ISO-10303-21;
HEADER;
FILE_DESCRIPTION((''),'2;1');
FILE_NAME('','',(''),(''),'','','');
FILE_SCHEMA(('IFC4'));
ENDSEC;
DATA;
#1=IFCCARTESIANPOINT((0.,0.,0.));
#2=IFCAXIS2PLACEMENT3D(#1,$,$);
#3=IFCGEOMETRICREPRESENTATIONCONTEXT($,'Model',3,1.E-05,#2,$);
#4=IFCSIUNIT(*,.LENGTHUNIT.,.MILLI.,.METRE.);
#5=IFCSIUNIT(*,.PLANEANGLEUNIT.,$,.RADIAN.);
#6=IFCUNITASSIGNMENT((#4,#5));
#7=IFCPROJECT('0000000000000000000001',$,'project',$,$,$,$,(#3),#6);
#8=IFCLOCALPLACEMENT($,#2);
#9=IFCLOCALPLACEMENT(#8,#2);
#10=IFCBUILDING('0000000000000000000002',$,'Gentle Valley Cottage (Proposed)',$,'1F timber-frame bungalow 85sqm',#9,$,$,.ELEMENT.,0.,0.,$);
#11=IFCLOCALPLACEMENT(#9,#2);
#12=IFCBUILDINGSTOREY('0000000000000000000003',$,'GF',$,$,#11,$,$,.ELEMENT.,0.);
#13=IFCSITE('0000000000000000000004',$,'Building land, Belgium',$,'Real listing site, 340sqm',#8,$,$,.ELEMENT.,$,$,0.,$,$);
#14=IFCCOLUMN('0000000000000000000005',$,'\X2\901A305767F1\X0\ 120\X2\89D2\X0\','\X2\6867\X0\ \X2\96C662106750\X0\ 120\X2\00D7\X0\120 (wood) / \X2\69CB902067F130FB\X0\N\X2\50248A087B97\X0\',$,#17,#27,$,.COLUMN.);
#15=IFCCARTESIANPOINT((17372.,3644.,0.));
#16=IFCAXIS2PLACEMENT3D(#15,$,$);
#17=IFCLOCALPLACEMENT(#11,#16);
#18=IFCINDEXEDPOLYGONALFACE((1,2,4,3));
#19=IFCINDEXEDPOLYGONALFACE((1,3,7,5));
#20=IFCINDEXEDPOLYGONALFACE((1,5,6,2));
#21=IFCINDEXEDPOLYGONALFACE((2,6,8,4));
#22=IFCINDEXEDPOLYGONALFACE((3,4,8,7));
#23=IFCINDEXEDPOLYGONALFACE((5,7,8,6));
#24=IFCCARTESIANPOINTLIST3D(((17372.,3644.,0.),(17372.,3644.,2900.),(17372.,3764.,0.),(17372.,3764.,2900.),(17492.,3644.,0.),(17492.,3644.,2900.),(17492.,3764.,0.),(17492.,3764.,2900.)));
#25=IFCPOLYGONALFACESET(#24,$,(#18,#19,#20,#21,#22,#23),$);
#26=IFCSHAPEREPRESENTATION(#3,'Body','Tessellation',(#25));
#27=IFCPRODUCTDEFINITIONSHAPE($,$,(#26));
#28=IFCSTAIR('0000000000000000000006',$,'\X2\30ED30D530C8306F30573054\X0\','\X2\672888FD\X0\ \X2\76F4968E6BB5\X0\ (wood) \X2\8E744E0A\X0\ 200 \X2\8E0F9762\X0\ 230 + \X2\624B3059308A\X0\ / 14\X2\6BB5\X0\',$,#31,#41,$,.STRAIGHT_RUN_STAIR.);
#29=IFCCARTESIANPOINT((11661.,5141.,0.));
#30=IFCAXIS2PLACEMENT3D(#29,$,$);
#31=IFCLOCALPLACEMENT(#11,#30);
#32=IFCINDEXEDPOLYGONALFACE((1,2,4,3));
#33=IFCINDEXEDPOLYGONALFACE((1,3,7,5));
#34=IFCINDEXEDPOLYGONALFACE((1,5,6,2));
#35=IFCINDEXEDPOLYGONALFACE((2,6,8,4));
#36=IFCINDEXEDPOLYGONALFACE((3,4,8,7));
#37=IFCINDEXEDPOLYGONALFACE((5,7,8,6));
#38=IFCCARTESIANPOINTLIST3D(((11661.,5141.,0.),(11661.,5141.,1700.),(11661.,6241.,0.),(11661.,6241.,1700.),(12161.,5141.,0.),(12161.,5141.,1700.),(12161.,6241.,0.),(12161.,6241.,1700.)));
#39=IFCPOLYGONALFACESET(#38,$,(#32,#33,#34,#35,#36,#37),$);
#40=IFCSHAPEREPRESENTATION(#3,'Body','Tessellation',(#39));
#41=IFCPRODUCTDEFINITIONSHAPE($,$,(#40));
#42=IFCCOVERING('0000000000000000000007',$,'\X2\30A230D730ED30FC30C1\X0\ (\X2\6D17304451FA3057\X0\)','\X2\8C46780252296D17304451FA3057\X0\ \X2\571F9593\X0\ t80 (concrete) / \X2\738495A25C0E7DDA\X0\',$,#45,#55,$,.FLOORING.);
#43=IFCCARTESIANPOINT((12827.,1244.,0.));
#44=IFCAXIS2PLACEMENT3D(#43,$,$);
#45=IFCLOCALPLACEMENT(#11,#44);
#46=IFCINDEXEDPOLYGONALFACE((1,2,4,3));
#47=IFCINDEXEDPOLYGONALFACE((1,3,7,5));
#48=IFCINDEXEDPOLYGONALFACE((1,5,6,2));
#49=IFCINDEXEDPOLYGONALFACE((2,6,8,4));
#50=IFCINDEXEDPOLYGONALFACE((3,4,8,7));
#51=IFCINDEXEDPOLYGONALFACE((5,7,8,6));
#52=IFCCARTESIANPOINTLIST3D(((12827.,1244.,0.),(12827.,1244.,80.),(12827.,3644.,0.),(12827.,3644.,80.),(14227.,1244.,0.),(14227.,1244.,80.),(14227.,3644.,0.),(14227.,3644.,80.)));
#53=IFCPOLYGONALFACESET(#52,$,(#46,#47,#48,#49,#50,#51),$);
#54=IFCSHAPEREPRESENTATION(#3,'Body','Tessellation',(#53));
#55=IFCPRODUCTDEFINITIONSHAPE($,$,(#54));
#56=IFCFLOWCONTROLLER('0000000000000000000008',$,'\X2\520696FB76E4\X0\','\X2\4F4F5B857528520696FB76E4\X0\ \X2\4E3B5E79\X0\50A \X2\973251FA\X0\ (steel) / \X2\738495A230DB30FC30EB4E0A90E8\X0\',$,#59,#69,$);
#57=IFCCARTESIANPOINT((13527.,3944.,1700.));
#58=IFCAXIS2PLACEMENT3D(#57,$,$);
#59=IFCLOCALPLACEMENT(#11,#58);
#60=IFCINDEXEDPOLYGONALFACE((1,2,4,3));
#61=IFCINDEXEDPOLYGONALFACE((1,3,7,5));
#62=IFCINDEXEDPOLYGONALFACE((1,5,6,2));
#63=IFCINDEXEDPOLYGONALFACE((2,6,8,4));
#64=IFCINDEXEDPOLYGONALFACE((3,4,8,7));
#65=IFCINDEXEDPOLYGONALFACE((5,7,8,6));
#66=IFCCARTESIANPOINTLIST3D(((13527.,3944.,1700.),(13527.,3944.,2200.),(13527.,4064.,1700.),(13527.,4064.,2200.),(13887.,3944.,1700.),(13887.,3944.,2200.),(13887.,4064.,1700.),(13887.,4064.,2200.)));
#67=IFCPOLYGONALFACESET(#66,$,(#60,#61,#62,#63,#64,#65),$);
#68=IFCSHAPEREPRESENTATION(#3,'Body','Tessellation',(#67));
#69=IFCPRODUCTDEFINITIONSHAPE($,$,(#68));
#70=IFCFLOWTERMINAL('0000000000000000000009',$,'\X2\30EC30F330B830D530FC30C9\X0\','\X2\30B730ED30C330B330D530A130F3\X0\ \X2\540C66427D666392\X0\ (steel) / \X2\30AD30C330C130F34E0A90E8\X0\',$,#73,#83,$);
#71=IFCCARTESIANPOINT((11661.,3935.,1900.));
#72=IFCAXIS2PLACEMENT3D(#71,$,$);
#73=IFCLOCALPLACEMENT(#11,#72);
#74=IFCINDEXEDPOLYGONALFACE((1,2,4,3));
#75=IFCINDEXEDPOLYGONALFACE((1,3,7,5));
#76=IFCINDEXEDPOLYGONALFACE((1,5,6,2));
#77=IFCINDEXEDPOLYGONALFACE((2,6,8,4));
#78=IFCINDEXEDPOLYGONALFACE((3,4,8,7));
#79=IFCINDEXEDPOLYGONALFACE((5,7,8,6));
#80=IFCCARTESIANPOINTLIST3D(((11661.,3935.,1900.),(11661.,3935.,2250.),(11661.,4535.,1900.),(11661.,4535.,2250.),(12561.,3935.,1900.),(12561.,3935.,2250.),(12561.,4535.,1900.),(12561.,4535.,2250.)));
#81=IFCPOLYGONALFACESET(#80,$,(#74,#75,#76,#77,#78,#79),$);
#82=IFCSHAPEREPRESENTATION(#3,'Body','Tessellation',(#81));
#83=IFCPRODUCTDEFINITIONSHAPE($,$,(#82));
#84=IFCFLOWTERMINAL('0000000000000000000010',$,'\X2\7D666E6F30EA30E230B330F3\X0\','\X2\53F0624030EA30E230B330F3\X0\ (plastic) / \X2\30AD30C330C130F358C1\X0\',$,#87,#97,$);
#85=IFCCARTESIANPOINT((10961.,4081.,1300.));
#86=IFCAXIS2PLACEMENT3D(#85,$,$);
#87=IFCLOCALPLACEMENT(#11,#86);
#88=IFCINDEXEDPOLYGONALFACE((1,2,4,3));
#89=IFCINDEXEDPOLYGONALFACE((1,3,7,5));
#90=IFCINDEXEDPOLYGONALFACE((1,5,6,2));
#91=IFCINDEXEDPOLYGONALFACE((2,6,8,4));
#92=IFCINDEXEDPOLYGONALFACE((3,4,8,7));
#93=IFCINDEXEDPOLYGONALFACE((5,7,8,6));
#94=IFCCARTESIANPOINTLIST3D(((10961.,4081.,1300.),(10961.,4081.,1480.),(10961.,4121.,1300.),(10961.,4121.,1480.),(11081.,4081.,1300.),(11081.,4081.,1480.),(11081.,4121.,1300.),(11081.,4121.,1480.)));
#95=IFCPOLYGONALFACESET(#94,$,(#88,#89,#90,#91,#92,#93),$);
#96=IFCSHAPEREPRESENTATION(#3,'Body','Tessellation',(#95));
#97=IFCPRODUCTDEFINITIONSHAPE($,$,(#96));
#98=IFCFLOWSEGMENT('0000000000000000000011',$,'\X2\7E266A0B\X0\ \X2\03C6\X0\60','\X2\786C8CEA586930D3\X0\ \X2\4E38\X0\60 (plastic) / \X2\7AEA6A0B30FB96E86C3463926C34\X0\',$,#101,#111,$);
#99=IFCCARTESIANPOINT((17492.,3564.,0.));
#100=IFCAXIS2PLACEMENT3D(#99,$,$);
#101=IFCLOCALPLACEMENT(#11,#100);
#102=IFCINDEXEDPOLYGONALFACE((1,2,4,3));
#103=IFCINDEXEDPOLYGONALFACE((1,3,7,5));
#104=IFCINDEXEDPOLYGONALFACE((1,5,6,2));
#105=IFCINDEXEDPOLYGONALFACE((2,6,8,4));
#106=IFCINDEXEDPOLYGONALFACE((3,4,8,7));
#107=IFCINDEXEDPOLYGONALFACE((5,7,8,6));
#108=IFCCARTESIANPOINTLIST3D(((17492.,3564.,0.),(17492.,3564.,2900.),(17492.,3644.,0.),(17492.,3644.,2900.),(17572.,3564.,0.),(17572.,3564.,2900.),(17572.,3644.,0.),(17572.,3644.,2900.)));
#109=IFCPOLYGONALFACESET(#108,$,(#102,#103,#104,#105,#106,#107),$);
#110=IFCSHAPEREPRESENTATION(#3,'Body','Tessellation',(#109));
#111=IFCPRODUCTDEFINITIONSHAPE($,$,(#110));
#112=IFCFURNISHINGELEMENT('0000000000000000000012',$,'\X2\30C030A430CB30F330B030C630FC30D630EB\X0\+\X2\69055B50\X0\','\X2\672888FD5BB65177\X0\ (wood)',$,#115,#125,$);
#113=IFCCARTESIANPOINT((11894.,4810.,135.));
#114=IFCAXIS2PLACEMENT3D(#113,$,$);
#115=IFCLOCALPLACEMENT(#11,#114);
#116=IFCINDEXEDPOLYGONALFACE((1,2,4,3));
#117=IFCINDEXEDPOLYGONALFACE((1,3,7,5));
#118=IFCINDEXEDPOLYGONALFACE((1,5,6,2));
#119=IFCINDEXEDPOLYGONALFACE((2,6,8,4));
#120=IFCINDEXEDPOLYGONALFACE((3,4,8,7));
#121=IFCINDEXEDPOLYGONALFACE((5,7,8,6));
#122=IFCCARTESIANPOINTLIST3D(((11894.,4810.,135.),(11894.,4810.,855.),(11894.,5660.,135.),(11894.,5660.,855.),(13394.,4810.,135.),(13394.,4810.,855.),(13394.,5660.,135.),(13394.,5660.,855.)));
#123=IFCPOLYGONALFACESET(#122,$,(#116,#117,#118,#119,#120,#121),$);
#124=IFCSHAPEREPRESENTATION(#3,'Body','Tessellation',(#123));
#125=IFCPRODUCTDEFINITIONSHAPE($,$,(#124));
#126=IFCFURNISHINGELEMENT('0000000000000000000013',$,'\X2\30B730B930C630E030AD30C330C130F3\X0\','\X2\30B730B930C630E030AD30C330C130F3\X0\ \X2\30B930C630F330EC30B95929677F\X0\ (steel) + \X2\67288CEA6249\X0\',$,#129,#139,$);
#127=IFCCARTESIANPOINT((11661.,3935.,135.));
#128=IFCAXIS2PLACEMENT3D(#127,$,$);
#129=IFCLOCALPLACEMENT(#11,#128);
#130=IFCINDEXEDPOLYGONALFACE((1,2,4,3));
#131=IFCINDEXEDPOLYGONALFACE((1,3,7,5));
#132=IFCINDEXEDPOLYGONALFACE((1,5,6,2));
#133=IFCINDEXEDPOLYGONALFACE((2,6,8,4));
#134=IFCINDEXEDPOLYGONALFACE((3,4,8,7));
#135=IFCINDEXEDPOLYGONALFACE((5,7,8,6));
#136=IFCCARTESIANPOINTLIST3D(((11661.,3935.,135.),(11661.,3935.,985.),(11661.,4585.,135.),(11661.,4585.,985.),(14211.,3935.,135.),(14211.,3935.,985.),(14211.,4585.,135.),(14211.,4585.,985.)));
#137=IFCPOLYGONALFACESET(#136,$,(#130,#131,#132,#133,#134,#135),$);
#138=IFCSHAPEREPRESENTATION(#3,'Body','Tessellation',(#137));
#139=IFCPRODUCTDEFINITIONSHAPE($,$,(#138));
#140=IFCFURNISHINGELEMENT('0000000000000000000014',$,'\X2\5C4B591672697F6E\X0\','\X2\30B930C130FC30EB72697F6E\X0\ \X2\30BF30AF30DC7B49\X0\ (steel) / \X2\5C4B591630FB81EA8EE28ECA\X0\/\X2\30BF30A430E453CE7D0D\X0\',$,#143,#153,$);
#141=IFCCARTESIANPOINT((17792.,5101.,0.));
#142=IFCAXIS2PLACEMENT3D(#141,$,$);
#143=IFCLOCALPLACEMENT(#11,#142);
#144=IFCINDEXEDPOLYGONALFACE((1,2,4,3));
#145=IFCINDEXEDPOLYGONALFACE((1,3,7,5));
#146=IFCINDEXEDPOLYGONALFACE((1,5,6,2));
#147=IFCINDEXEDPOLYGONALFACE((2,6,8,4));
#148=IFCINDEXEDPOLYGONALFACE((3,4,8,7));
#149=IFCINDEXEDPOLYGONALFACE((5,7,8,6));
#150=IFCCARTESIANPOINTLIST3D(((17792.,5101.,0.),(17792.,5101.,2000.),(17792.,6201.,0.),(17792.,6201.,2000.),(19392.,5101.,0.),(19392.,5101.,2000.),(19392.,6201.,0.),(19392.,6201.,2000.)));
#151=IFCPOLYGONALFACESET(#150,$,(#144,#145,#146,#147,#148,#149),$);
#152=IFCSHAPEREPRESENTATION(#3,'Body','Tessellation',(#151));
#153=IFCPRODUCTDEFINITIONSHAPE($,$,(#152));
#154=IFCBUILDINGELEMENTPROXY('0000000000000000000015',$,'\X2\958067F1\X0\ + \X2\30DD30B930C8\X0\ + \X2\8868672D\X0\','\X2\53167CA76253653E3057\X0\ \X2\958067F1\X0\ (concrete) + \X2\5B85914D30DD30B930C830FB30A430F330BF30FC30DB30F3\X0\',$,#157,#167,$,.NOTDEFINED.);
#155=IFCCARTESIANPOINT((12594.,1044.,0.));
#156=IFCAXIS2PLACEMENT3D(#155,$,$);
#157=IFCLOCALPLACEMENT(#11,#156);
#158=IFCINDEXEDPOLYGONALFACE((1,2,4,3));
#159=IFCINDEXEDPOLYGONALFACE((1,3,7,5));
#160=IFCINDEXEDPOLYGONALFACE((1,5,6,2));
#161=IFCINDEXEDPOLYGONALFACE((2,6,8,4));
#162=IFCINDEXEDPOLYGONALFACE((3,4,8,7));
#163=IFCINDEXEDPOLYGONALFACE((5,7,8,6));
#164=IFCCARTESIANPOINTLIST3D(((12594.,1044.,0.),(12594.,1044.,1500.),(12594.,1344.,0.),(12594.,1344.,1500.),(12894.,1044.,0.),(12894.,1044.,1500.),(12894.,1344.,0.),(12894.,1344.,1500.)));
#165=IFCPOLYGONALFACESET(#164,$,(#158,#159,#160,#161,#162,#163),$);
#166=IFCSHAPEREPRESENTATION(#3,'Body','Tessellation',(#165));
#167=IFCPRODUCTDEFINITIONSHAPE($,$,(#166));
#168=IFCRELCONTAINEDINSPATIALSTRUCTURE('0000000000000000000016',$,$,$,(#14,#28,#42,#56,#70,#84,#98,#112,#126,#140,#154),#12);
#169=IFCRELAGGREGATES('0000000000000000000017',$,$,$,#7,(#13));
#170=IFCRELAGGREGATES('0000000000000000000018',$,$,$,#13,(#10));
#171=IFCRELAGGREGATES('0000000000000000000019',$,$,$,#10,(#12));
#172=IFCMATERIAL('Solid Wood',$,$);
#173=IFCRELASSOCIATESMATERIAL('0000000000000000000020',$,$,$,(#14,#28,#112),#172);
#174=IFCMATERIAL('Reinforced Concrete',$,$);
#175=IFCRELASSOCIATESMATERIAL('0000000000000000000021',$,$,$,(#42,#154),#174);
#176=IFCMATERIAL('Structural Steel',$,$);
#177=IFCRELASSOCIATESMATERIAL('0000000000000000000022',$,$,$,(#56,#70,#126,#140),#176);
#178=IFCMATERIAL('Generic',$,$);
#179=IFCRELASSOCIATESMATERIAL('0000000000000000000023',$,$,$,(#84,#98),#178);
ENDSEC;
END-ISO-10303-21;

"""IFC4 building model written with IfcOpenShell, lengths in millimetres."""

from ifc_helpers import new_model, si_unit, frame, frame_2d, origin, place, context, project, spatial, rectangle, extrude, material, element, save


model = new_model("IFC4")

# Units and contexts
model_context = context("Model", 3, precision=1e-05, world=origin())
ifc_project = project(units=[si_unit("LENGTHUNIT", "METRE", prefix="MILLI"), si_unit("PLANEANGLEUNIT", "RADIAN")], contexts=[model_context])

# Site, building, storey
site_placement = place(None, origin())
site = spatial("IfcSite", under=ifc_project, at=site_placement, Name="Building land, Belgium", ObjectType="Real listing site, 340sqm", CompositionType="ELEMENT", RefElevation=0.0)
building_placement = place(site_placement, origin())
building = spatial("IfcBuilding", under=site, at=building_placement, Name="Gentle Valley Cottage (Proposed)", ObjectType="1F timber-frame bungalow 85sqm", CompositionType="ELEMENT", ElevationOfRefHeight=0.0, ElevationOfTerrain=0.0)
storey_placement = place(building_placement, origin())
storey = spatial("IfcBuildingStorey", under=building, at=storey_placement, Name="GF", CompositionType="ELEMENT", Elevation=0.0)

# Column
ifc_material_1 = material(Name="Solid Wood")
column_1_placement = place(storey_placement, frame((17372.0, 3644.0, 0.0)))
element("IfcColumn", 1, at=column_1_placement, inside=storey, material=ifc_material_1, Name="通し柱 120角", Description="桧 集成材 120×120 (wood) / 構造柱・N値計算", PredefinedType="COLUMN", context=model_context, shape_type="SweptSolid", body=[
    extrude(rectangle(XDim=120.0, YDim=120.0, at=frame_2d((60.0, 60.0))), frame((17372.0, 3644.0, 0.0)), (0.0, 0.0, 1.0), 2900.0),
])

# Stair
stair_placement = place(storey_placement, frame((11661.0, 5141.0, 0.0)))
element("IfcStair", 2, at=stair_placement, inside=storey, material=ifc_material_1, Name="ロフトはしご", Description="木製 直階段 (wood) 蹴上 200 踏面 230 + 手すり / 14段", PredefinedType="STRAIGHT_RUN_STAIR", context=model_context, shape_type="SweptSolid", body=[
    extrude(rectangle(XDim=500.0, YDim=1100.0, at=frame_2d((250.0, 550.0))), frame((11661.0, 5141.0, 0.0)), (0.0, 0.0, 1.0), 1700.0),
])

# Covering
ifc_material_2 = material(Name="Reinforced Concrete")
covering_placement = place(storey_placement, frame((12827.0, 1244.0, 0.0)))
element("IfcCovering", 3, at=covering_placement, inside=storey, material=ifc_material_2, Name="アプローチ (洗い出し)", Description="豆砂利洗い出し 土間 t80 (concrete) / 玄関導線", PredefinedType="FLOORING", context=model_context, shape_type="SweptSolid", body=[
    extrude(rectangle(XDim=1400.0, YDim=2400.0, at=frame_2d((700.0, 1200.0))), frame((12827.0, 1244.0, 0.0)), (0.0, 0.0, 1.0), 80.0),
])

# Flow controller
ifc_material_3 = material(Name="Structural Steel")
flow_controller_placement = place(storey_placement, frame((13527.0, 3944.0, 1700.0)))
element("IfcFlowController", 4, at=flow_controller_placement, inside=storey, material=ifc_material_3, Name="分電盤", Description="住宅用分電盤 主幹50A 露出 (steel) / 玄関ホール上部", context=model_context, shape_type="SweptSolid", body=[
    extrude(rectangle(XDim=360.0, YDim=120.0, at=frame_2d((180.0, 60.0))), frame((13527.0, 3944.0, 1700.0)), (0.0, 0.0, 1.0), 500.0),
])

# Flow terminals
flow_terminal_1_placement = place(storey_placement, frame((11661.0, 3935.0, 1900.0)))
element("IfcFlowTerminal", 5, at=flow_terminal_1_placement, inside=storey, material=ifc_material_3, Name="レンジフード", Description="シロッコファン 同時給排 (steel) / キッチン上部", context=model_context, shape_type="SweptSolid", body=[
    extrude(rectangle(XDim=900.0, YDim=600.0, at=frame_2d((450.0, 300.0))), frame((11661.0, 3935.0, 1900.0)), (0.0, 0.0, 1.0), 350.0),
])
ifc_material_4 = material(Name="Generic")
flow_terminal_2_placement = place(storey_placement, frame((10961.0, 4081.0, 1300.0)))
element("IfcFlowTerminal", 6, at=flow_terminal_2_placement, inside=storey, material=ifc_material_4, Name="給湯リモコン", Description="台所リモコン (plastic) / キッチン壁", context=model_context, shape_type="SweptSolid", body=[
    extrude(rectangle(XDim=120.0, YDim=40.0, at=frame_2d((60.0, 20.0))), frame((10961.0, 4081.0, 1300.0)), (0.0, 0.0, 1.0), 180.0),
])

# Flow segment
flow_segment_placement = place(storey_placement, frame((17492.0, 3564.0, 0.0)))
element("IfcFlowSegment", 7, at=flow_segment_placement, inside=storey, material=ifc_material_4, Name="縦樋 φ60", Description="硬質塩ビ 丸60 (plastic) / 竪樋・雨水排水", context=model_context, shape_type="SweptSolid", body=[
    extrude(rectangle(XDim=80.0, YDim=80.0, at=frame_2d((40.0, 40.0))), frame((17492.0, 3564.0, 0.0)), (0.0, 0.0, 1.0), 2900.0),
])

# Furnishing elements
furnishing_1_placement = place(storey_placement, frame((11894.0, 4810.0, 135.0)))
element("IfcFurnishingElement", 8, at=furnishing_1_placement, inside=storey, material=ifc_material_1, Name="ダイニングテーブル+椅子", Description="木製家具 (wood)", context=model_context, shape_type="SweptSolid", body=[
    extrude(rectangle(XDim=1500.0, YDim=850.0, at=frame_2d((750.0, 425.0))), frame((11894.0, 4810.0, 135.0)), (0.0, 0.0, 1.0), 720.0),
])
furnishing_2_placement = place(storey_placement, frame((11661.0, 3935.0, 135.0)))
element("IfcFurnishingElement", 9, at=furnishing_2_placement, inside=storey, material=ifc_material_3, Name="システムキッチン", Description="システムキッチン ステンレス天板 (steel) + 木質扉", context=model_context, shape_type="SweptSolid", body=[
    extrude(rectangle(XDim=2550.0, YDim=650.0, at=frame_2d((1275.0, 325.0))), frame((11661.0, 3935.0, 135.0)), (0.0, 0.0, 1.0), 850.0),
])
furnishing_3_placement = place(storey_placement, frame((17792.0, 5101.0, 0.0)))
element("IfcFurnishingElement", 10, at=furnishing_3_placement, inside=storey, material=ifc_material_3, Name="屋外物置", Description="スチール物置 タクボ等 (steel) / 屋外・自転車/タイヤ収納", context=model_context, shape_type="SweptSolid", body=[
    extrude(rectangle(XDim=1600.0, YDim=1100.0, at=frame_2d((800.0, 550.0))), frame((17792.0, 5101.0, 0.0)), (0.0, 0.0, 1.0), 2000.0),
])

# Building element proxy
proxy_placement = place(storey_placement, frame((12594.0, 1044.0, 0.0)))
element("IfcBuildingElementProxy", 11, at=proxy_placement, inside=storey, material=ifc_material_2, Name="門柱 + ポスト + 表札", Description="化粧打放し 門柱 (concrete) + 宅配ポスト・インターホン", PredefinedType="NOTDEFINED", context=model_context, shape_type="SweptSolid", body=[
    extrude(rectangle(XDim=300.0, YDim=300.0, at=frame_2d((150.0, 150.0))), frame((12594.0, 1044.0, 0.0)), (0.0, 0.0, 1.0), 1500.0),
])

save(model, "model.ifc")
